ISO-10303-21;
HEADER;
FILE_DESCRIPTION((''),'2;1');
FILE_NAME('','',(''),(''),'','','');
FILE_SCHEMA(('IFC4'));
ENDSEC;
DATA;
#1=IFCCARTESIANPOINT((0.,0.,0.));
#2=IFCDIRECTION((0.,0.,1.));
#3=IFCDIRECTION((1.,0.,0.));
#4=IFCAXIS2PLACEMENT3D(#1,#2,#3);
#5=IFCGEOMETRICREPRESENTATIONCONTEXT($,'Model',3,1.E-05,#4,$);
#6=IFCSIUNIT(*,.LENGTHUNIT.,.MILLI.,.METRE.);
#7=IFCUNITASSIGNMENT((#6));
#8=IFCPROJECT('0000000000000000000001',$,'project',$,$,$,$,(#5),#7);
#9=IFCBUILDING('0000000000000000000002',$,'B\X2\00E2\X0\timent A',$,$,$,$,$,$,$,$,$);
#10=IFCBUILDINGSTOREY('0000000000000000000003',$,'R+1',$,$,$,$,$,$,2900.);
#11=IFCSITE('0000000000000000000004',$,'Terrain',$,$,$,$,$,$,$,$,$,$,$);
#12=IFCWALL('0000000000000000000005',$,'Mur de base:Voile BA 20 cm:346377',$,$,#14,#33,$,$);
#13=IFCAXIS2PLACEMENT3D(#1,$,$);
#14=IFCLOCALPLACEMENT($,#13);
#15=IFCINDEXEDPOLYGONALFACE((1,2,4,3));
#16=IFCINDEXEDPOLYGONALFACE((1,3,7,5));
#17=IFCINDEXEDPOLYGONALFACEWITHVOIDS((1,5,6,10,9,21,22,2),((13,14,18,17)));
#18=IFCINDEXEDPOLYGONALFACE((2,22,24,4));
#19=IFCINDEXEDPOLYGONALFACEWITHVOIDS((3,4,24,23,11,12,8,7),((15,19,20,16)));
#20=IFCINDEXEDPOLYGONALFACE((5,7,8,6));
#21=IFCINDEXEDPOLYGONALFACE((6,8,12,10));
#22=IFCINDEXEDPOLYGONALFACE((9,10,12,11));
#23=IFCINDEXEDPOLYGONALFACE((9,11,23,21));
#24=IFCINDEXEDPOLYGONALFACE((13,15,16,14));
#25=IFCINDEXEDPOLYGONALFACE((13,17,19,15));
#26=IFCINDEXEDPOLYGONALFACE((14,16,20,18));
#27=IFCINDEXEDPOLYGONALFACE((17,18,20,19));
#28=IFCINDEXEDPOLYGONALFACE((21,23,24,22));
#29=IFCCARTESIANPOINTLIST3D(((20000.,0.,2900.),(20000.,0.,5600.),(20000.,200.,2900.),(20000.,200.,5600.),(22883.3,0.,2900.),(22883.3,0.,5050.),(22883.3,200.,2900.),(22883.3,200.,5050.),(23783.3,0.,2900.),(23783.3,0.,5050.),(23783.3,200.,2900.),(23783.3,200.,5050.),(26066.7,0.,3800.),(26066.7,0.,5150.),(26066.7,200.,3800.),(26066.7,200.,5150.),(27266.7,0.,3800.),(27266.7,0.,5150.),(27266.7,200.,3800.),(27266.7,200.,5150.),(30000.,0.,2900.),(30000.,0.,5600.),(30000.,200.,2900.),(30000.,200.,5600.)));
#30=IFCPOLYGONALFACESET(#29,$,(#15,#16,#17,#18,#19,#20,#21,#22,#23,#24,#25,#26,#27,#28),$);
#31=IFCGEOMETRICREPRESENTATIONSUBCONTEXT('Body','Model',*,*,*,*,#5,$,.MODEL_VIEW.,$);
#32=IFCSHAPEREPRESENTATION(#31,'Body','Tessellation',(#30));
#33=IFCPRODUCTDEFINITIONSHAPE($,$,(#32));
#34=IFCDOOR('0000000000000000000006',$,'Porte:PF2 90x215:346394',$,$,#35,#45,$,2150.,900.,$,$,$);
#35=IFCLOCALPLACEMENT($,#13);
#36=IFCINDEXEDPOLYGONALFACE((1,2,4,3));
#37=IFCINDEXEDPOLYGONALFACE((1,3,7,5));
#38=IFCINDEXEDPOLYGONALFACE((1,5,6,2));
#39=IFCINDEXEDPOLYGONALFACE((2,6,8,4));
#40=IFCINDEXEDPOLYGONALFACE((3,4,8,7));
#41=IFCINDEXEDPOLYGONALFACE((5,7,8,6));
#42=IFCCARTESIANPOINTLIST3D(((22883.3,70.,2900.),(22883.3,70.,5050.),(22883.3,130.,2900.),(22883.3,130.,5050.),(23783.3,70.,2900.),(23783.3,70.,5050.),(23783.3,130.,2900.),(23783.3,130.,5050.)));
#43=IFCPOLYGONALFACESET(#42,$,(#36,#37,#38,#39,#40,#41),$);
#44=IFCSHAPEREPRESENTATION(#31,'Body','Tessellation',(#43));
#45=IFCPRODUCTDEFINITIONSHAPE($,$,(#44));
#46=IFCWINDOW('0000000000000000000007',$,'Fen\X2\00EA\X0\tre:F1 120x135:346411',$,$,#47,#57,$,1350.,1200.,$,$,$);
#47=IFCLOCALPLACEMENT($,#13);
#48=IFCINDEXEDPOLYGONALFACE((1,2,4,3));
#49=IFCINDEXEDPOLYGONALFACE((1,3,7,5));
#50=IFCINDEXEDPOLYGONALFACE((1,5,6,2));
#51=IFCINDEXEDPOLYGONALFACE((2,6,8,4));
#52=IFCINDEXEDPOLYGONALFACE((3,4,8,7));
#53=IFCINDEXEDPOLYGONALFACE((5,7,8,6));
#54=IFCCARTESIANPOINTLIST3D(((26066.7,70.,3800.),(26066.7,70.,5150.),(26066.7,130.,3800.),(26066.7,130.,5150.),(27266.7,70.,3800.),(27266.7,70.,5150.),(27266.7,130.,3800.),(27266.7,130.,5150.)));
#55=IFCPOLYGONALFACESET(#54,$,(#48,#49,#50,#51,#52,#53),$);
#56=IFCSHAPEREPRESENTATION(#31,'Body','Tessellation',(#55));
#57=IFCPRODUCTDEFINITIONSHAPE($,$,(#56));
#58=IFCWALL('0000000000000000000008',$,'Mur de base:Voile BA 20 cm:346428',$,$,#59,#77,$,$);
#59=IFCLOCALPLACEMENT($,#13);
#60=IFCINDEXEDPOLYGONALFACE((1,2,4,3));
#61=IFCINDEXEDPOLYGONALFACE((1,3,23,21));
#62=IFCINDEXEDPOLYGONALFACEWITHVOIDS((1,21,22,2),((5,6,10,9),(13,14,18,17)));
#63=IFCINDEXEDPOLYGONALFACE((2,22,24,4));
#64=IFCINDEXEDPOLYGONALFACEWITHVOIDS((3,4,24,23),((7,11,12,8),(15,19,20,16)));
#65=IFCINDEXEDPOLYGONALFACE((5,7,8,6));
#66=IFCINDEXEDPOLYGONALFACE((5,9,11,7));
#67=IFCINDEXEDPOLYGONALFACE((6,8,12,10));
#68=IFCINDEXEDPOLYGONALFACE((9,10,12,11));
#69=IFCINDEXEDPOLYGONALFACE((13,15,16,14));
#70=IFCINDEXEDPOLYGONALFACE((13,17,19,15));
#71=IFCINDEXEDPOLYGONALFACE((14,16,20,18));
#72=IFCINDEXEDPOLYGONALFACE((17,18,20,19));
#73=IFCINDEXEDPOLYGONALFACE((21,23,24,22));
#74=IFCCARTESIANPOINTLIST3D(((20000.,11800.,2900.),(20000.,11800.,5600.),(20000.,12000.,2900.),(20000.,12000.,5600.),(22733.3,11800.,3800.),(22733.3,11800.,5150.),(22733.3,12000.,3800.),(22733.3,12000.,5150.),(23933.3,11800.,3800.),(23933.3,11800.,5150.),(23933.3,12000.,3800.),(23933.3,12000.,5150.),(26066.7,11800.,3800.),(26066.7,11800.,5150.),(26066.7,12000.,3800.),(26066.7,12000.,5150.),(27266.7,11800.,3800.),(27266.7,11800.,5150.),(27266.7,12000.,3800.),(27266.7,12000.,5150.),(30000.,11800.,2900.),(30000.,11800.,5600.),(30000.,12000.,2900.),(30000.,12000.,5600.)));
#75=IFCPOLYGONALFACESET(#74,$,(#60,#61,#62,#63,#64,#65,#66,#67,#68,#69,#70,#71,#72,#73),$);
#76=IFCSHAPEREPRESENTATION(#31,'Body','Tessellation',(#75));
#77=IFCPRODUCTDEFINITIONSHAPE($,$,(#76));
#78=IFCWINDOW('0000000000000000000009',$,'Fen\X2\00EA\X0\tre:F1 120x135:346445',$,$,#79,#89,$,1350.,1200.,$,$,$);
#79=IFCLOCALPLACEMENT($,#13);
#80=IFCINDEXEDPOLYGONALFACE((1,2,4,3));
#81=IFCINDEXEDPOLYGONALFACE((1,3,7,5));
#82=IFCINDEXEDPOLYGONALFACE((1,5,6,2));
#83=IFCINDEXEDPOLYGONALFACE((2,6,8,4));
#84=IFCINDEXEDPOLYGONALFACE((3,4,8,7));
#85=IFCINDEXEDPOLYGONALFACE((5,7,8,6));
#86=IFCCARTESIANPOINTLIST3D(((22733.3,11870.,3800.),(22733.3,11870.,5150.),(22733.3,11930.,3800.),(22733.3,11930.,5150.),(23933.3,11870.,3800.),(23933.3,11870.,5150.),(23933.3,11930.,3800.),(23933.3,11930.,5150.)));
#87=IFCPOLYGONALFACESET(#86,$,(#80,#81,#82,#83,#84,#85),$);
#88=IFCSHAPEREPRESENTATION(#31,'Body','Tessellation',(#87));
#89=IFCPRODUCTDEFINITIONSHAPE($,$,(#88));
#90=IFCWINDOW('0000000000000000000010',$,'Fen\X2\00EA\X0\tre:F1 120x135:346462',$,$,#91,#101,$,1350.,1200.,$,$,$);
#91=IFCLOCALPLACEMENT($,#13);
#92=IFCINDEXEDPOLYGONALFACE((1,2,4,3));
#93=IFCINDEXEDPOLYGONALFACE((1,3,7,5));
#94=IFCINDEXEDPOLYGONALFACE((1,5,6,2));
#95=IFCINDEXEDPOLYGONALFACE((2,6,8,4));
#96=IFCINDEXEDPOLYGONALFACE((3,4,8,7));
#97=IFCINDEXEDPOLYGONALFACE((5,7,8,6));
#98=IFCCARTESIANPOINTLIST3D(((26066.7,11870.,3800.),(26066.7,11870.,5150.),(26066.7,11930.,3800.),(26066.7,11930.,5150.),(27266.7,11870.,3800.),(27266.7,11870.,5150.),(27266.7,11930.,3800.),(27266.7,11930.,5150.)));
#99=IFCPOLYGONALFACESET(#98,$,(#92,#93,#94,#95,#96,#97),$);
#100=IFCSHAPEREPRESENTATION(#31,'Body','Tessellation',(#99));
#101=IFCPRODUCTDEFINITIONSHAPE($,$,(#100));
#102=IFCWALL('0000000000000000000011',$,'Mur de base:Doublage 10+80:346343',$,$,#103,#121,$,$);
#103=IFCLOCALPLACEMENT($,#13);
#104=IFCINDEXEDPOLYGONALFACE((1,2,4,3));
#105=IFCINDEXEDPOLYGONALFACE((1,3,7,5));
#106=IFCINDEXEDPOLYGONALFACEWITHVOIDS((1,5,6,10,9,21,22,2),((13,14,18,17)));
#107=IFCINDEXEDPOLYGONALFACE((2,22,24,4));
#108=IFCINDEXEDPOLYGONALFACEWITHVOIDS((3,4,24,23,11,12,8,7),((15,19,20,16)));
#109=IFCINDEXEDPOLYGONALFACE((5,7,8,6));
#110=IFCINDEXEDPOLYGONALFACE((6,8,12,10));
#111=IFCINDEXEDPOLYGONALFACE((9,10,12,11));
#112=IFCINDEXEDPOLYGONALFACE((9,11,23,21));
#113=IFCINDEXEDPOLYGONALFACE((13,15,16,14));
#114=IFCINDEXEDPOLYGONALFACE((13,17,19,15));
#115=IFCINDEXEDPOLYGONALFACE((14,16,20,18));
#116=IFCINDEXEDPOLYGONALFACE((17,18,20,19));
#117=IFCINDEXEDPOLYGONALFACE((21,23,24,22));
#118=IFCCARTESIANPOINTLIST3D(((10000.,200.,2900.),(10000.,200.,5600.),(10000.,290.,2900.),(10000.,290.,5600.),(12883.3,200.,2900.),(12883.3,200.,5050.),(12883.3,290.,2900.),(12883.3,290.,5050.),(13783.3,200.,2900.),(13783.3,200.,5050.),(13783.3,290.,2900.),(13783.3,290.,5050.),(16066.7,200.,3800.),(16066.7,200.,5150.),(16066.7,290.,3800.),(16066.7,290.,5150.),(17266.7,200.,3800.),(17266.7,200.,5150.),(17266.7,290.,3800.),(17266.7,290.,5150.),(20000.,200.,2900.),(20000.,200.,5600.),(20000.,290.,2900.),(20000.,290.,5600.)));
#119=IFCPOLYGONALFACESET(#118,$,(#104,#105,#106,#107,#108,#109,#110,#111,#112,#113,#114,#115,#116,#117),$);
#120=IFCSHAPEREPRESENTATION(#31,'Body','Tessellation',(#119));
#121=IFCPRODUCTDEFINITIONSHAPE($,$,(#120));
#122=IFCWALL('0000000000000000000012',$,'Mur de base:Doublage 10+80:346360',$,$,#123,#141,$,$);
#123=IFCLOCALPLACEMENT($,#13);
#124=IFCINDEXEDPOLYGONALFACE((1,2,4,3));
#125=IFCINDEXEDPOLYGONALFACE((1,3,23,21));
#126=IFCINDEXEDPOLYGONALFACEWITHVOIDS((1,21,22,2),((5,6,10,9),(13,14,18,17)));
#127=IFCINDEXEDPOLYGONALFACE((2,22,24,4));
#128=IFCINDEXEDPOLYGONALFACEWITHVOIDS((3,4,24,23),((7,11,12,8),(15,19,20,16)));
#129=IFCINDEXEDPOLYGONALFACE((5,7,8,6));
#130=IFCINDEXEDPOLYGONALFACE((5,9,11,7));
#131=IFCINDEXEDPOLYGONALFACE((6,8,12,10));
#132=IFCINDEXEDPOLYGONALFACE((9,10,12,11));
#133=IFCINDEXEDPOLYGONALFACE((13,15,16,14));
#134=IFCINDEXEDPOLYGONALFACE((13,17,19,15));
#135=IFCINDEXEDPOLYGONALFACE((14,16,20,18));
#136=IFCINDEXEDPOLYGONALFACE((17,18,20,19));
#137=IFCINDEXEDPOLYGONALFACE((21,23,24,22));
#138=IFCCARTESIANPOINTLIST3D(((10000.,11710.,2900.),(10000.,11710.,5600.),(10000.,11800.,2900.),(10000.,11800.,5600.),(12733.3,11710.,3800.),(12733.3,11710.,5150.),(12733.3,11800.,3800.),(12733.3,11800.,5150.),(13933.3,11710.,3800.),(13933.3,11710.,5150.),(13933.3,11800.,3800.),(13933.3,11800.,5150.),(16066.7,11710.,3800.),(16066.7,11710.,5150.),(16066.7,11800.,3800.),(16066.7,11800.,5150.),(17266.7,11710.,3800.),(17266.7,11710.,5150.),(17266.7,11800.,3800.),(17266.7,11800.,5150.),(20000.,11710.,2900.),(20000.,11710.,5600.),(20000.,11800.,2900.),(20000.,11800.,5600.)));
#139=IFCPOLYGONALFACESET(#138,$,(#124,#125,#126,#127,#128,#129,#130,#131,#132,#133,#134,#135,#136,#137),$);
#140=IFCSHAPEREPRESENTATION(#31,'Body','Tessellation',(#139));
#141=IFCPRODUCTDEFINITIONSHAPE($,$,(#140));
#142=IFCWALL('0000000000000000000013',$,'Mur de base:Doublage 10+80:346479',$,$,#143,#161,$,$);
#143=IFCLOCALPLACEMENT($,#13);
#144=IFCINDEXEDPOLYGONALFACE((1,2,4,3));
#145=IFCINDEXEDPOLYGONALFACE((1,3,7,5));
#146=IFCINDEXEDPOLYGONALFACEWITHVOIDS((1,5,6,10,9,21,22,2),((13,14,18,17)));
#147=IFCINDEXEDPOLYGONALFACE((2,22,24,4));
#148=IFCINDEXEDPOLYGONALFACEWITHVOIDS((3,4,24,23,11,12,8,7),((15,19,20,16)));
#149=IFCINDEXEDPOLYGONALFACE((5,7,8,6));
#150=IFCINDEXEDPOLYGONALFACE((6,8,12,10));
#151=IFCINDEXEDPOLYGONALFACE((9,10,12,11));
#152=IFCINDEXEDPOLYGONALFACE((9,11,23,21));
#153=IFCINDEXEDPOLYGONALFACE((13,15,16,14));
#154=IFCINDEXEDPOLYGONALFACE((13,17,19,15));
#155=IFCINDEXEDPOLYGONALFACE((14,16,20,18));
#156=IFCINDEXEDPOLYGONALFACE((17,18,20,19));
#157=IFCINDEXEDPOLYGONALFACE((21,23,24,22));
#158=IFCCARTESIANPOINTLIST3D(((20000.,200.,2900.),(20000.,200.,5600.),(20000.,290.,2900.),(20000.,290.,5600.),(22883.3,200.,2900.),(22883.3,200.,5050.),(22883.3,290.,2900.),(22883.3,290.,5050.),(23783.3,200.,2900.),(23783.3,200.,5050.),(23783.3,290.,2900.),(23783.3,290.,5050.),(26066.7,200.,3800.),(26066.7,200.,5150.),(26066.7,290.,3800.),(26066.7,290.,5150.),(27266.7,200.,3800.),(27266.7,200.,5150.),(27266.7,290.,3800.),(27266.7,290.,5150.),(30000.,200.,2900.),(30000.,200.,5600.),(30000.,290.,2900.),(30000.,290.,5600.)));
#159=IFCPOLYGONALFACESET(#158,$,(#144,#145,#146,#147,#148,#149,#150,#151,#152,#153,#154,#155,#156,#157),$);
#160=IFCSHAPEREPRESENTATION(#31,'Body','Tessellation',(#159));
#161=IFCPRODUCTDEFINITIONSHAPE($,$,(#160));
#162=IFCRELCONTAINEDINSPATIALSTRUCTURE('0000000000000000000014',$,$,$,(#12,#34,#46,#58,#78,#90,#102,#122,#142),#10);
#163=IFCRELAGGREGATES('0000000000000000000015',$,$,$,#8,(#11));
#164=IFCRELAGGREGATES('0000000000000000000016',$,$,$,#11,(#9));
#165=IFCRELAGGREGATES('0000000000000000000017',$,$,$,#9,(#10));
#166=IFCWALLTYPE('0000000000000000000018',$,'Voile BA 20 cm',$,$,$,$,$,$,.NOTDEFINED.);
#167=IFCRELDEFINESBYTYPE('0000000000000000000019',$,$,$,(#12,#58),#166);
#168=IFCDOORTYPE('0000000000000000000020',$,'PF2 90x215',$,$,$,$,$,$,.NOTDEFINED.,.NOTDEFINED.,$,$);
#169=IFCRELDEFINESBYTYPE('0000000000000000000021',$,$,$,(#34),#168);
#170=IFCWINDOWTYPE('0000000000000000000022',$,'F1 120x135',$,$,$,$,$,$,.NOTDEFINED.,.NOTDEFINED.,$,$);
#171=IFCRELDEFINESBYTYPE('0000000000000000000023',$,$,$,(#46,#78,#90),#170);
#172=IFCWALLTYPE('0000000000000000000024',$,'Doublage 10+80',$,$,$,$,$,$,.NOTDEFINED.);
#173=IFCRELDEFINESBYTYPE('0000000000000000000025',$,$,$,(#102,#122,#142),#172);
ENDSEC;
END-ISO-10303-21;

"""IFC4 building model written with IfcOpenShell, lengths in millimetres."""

from ifc_helpers import new_model, si_unit, frame, frame_2d, origin_with_axes, place, context, subcontext, project, spatial, rectangle, extrude, type_object, element, fill, save


model = new_model("IFC4")

# Units and contexts
model_context = context("Model", 3, precision=1e-05, world=origin_with_axes())
body_context = subcontext(model_context, "Body", "Model", "MODEL_VIEW")
ifc_project = project(units=[si_unit("LENGTHUNIT", "METRE", prefix="MILLI")], contexts=[model_context])

# Site, building, storey
site = spatial("IfcSite", under=ifc_project, Name="Terrain")
building = spatial("IfcBuilding", under=site, Name="Bâtiment A")
storey = spatial("IfcBuildingStorey", under=building, Name="R+1", Elevation=2900.0)

# Wall, openings, door, window
wall_type_1 = type_object("IfcWallType", Name="Voile BA 20 cm", PredefinedType="NOTDEFINED")
wall_1_placement = place(None, origin_with_axes())
wall_1 = element("IfcWall", 1, at=wall_1_placement, inside=storey, type_object=wall_type_1, Name="Mur de base:Voile BA 20 cm:346377", context=body_context, shape_type="SweptSolid", body=[
    extrude(rectangle(XDim=10000.0, YDim=200.0, at=frame_2d((25000.0, 100.0))), frame((0.0, 0.0, 2900.0), z_axis=(0.0, 0.0, 1.0), x_axis=(1.0, 0.0, 0.0)), (0.0, 0.0, 1.0), 2700.0),
])
opening_1_placement = place(None, origin_with_axes())
opening_1 = element("IfcOpeningElement", 2, at=opening_1_placement, cuts=wall_1, context=body_context, shape_type="SweptSolid", body=[
    extrude(rectangle(XDim=900.0, YDim=320.0, at=frame_2d((23333.3, 100.0))), frame((0.0, 0.0, 2900.0), z_axis=(0.0, 0.0, 1.0), x_axis=(1.0, 0.0, 0.0)), (0.0, 0.0, 1.0), 2150.0),
])
opening_2_placement = place(None, origin_with_axes())
opening_2 = element("IfcOpeningElement", 3, at=opening_2_placement, cuts=wall_1, context=body_context, shape_type="SweptSolid", body=[
    extrude(rectangle(XDim=1200.0, YDim=320.0, at=frame_2d((26666.7, 100.0))), frame((0.0, 0.0, 3800.0), z_axis=(0.0, 0.0, 1.0), x_axis=(1.0, 0.0, 0.0)), (0.0, 0.0, 1.0), 1350.0),
])
door_type = type_object("IfcDoorType", Name="PF2 90x215", OperationType="NOTDEFINED", PredefinedType="NOTDEFINED")
door_placement = place(None, origin_with_axes())
door = element("IfcDoor", 4, at=door_placement, inside=storey, type_object=door_type, Name="Porte:PF2 90x215:346394", OverallHeight=2150.0, OverallWidth=900.0, context=body_context, shape_type="SweptSolid", body=[
    extrude(rectangle(XDim=900.0, YDim=60.0, at=frame_2d((23333.3, 100.0))), frame((0.0, 0.0, 2900.0), z_axis=(0.0, 0.0, 1.0), x_axis=(1.0, 0.0, 0.0)), (0.0, 0.0, 1.0), 2150.0),
])
fill(opening_1, door)
window_type = type_object("IfcWindowType", Name="F1 120x135", PartitioningType="NOTDEFINED", PredefinedType="NOTDEFINED")
window_1_placement = place(None, origin_with_axes())
window_1 = element("IfcWindow", 5, at=window_1_placement, inside=storey, type_object=window_type, Name="Fenêtre:F1 120x135:346411", OverallHeight=1350.0, OverallWidth=1200.0, context=body_context, shape_type="SweptSolid", body=[
    extrude(rectangle(XDim=1200.0, YDim=60.0, at=frame_2d((26666.7, 100.0))), frame((0.0, 0.0, 3800.0), z_axis=(0.0, 0.0, 1.0), x_axis=(1.0, 0.0, 0.0)), (0.0, 0.0, 1.0), 1350.0),
])
fill(opening_2, window_1)

# Wall, openings, windows
wall_2_placement = place(None, origin_with_axes())
wall_2 = element("IfcWall", 6, at=wall_2_placement, inside=storey, type_object=wall_type_1, Name="Mur de base:Voile BA 20 cm:346428", context=body_context, shape_type="SweptSolid", body=[
    extrude(rectangle(XDim=10000.0, YDim=200.0, at=frame_2d((25000.0, 11900.0))), frame((0.0, 0.0, 2900.0), z_axis=(0.0, 0.0, 1.0), x_axis=(1.0, 0.0, 0.0)), (0.0, 0.0, 1.0), 2700.0),
])
opening_3_placement = place(None, origin_with_axes())
opening_3 = element("IfcOpeningElement", 7, at=opening_3_placement, cuts=wall_2, context=body_context, shape_type="SweptSolid", body=[
    extrude(rectangle(XDim=1200.0, YDim=320.0, at=frame_2d((23333.3, 11900.0))), frame((0.0, 0.0, 3800.0), z_axis=(0.0, 0.0, 1.0), x_axis=(1.0, 0.0, 0.0)), (0.0, 0.0, 1.0), 1350.0),
])
opening_4_placement = place(None, origin_with_axes())
opening_4 = element("IfcOpeningElement", 8, at=opening_4_placement, cuts=wall_2, context=body_context, shape_type="SweptSolid", body=[
    extrude(rectangle(XDim=1200.0, YDim=320.0, at=frame_2d((26666.7, 11900.0))), frame((0.0, 0.0, 3800.0), z_axis=(0.0, 0.0, 1.0), x_axis=(1.0, 0.0, 0.0)), (0.0, 0.0, 1.0), 1350.0),
])
window_2_placement = place(None, origin_with_axes())
window_2 = element("IfcWindow", 9, at=window_2_placement, inside=storey, type_object=window_type, Name="Fenêtre:F1 120x135:346445", OverallHeight=1350.0, OverallWidth=1200.0, context=body_context, shape_type="SweptSolid", body=[
    extrude(rectangle(XDim=1200.0, YDim=60.0, at=frame_2d((23333.3, 11900.0))), frame((0.0, 0.0, 3800.0), z_axis=(0.0, 0.0, 1.0), x_axis=(1.0, 0.0, 0.0)), (0.0, 0.0, 1.0), 1350.0),
])
fill(opening_3, window_2)
window_3_placement = place(None, origin_with_axes())
window_3 = element("IfcWindow", 10, at=window_3_placement, inside=storey, type_object=window_type, Name="Fenêtre:F1 120x135:346462", OverallHeight=1350.0, OverallWidth=1200.0, context=body_context, shape_type="SweptSolid", body=[
    extrude(rectangle(XDim=1200.0, YDim=60.0, at=frame_2d((26666.7, 11900.0))), frame((0.0, 0.0, 3800.0), z_axis=(0.0, 0.0, 1.0), x_axis=(1.0, 0.0, 0.0)), (0.0, 0.0, 1.0), 1350.0),
])
fill(opening_4, window_3)

# Walls, openings
wall_type_2 = type_object("IfcWallType", Name="Doublage 10+80", PredefinedType="NOTDEFINED")
wall_3_placement = place(None, origin_with_axes())
wall_3 = element("IfcWall", 11, at=wall_3_placement, inside=storey, type_object=wall_type_2, Name="Mur de base:Doublage 10+80:346343", context=body_context, shape_type="SweptSolid", body=[
    extrude(rectangle(XDim=10000.0, YDim=90.0, at=frame_2d((15000.0, 245.0))), frame((0.0, 0.0, 2900.0), z_axis=(0.0, 0.0, 1.0), x_axis=(1.0, 0.0, 0.0)), (0.0, 0.0, 1.0), 2700.0),
])
opening_5_placement = place(None, origin_with_axes())
element("IfcOpeningElement", 12, at=opening_5_placement, cuts=wall_3, context=body_context, shape_type="SweptSolid", body=[
    extrude(rectangle(XDim=900.0, YDim=210.0, at=frame_2d((13333.3, 245.0))), frame((0.0, 0.0, 2900.0), z_axis=(0.0, 0.0, 1.0), x_axis=(1.0, 0.0, 0.0)), (0.0, 0.0, 1.0), 2150.0),
])
opening_6_placement = place(None, origin_with_axes())
element("IfcOpeningElement", 13, at=opening_6_placement, cuts=wall_3, context=body_context, shape_type="SweptSolid", body=[
    extrude(rectangle(XDim=1200.0, YDim=210.0, at=frame_2d((16666.7, 245.0))), frame((0.0, 0.0, 3800.0), z_axis=(0.0, 0.0, 1.0), x_axis=(1.0, 0.0, 0.0)), (0.0, 0.0, 1.0), 1350.0),
])
wall_4_placement = place(None, origin_with_axes())
wall_4 = element("IfcWall", 14, at=wall_4_placement, inside=storey, type_object=wall_type_2, Name="Mur de base:Doublage 10+80:346360", context=body_context, shape_type="SweptSolid", body=[
    extrude(rectangle(XDim=10000.0, YDim=90.0, at=frame_2d((15000.0, 11755.0))), frame((0.0, 0.0, 2900.0), z_axis=(0.0, 0.0, 1.0), x_axis=(1.0, 0.0, 0.0)), (0.0, 0.0, 1.0), 2700.0),
])
opening_7_placement = place(None, origin_with_axes())
element("IfcOpeningElement", 15, at=opening_7_placement, cuts=wall_4, context=body_context, shape_type="SweptSolid", body=[
    extrude(rectangle(XDim=1200.0, YDim=210.0, at=frame_2d((13333.3, 11755.0))), frame((0.0, 0.0, 3800.0), z_axis=(0.0, 0.0, 1.0), x_axis=(1.0, 0.0, 0.0)), (0.0, 0.0, 1.0), 1350.0),
])
opening_8_placement = place(None, origin_with_axes())
element("IfcOpeningElement", 16, at=opening_8_placement, cuts=wall_4, context=body_context, shape_type="SweptSolid", body=[
    extrude(rectangle(XDim=1200.0, YDim=210.0, at=frame_2d((16666.7, 11755.0))), frame((0.0, 0.0, 3800.0), z_axis=(0.0, 0.0, 1.0), x_axis=(1.0, 0.0, 0.0)), (0.0, 0.0, 1.0), 1350.0),
])
wall_5_placement = place(None, origin_with_axes())
wall_5 = element("IfcWall", 17, at=wall_5_placement, inside=storey, type_object=wall_type_2, Name="Mur de base:Doublage 10+80:346479", context=body_context, shape_type="SweptSolid", body=[
    extrude(rectangle(XDim=10000.0, YDim=90.0, at=frame_2d((25000.0, 245.0))), frame((0.0, 0.0, 2900.0), z_axis=(0.0, 0.0, 1.0), x_axis=(1.0, 0.0, 0.0)), (0.0, 0.0, 1.0), 2700.0),
])
opening_9_placement = place(None, origin_with_axes())
element("IfcOpeningElement", 18, at=opening_9_placement, cuts=wall_5, context=body_context, shape_type="SweptSolid", body=[
    extrude(rectangle(XDim=900.0, YDim=210.0, at=frame_2d((23333.3, 245.0))), frame((0.0, 0.0, 2900.0), z_axis=(0.0, 0.0, 1.0), x_axis=(1.0, 0.0, 0.0)), (0.0, 0.0, 1.0), 2150.0),
])
opening_10_placement = place(None, origin_with_axes())
element("IfcOpeningElement", 19, at=opening_10_placement, cuts=wall_5, context=body_context, shape_type="SweptSolid", body=[
    extrude(rectangle(XDim=1200.0, YDim=210.0, at=frame_2d((26666.7, 245.0))), frame((0.0, 0.0, 3800.0), z_axis=(0.0, 0.0, 1.0), x_axis=(1.0, 0.0, 0.0)), (0.0, 0.0, 1.0), 1350.0),
])

save(model, "model.ifc")
